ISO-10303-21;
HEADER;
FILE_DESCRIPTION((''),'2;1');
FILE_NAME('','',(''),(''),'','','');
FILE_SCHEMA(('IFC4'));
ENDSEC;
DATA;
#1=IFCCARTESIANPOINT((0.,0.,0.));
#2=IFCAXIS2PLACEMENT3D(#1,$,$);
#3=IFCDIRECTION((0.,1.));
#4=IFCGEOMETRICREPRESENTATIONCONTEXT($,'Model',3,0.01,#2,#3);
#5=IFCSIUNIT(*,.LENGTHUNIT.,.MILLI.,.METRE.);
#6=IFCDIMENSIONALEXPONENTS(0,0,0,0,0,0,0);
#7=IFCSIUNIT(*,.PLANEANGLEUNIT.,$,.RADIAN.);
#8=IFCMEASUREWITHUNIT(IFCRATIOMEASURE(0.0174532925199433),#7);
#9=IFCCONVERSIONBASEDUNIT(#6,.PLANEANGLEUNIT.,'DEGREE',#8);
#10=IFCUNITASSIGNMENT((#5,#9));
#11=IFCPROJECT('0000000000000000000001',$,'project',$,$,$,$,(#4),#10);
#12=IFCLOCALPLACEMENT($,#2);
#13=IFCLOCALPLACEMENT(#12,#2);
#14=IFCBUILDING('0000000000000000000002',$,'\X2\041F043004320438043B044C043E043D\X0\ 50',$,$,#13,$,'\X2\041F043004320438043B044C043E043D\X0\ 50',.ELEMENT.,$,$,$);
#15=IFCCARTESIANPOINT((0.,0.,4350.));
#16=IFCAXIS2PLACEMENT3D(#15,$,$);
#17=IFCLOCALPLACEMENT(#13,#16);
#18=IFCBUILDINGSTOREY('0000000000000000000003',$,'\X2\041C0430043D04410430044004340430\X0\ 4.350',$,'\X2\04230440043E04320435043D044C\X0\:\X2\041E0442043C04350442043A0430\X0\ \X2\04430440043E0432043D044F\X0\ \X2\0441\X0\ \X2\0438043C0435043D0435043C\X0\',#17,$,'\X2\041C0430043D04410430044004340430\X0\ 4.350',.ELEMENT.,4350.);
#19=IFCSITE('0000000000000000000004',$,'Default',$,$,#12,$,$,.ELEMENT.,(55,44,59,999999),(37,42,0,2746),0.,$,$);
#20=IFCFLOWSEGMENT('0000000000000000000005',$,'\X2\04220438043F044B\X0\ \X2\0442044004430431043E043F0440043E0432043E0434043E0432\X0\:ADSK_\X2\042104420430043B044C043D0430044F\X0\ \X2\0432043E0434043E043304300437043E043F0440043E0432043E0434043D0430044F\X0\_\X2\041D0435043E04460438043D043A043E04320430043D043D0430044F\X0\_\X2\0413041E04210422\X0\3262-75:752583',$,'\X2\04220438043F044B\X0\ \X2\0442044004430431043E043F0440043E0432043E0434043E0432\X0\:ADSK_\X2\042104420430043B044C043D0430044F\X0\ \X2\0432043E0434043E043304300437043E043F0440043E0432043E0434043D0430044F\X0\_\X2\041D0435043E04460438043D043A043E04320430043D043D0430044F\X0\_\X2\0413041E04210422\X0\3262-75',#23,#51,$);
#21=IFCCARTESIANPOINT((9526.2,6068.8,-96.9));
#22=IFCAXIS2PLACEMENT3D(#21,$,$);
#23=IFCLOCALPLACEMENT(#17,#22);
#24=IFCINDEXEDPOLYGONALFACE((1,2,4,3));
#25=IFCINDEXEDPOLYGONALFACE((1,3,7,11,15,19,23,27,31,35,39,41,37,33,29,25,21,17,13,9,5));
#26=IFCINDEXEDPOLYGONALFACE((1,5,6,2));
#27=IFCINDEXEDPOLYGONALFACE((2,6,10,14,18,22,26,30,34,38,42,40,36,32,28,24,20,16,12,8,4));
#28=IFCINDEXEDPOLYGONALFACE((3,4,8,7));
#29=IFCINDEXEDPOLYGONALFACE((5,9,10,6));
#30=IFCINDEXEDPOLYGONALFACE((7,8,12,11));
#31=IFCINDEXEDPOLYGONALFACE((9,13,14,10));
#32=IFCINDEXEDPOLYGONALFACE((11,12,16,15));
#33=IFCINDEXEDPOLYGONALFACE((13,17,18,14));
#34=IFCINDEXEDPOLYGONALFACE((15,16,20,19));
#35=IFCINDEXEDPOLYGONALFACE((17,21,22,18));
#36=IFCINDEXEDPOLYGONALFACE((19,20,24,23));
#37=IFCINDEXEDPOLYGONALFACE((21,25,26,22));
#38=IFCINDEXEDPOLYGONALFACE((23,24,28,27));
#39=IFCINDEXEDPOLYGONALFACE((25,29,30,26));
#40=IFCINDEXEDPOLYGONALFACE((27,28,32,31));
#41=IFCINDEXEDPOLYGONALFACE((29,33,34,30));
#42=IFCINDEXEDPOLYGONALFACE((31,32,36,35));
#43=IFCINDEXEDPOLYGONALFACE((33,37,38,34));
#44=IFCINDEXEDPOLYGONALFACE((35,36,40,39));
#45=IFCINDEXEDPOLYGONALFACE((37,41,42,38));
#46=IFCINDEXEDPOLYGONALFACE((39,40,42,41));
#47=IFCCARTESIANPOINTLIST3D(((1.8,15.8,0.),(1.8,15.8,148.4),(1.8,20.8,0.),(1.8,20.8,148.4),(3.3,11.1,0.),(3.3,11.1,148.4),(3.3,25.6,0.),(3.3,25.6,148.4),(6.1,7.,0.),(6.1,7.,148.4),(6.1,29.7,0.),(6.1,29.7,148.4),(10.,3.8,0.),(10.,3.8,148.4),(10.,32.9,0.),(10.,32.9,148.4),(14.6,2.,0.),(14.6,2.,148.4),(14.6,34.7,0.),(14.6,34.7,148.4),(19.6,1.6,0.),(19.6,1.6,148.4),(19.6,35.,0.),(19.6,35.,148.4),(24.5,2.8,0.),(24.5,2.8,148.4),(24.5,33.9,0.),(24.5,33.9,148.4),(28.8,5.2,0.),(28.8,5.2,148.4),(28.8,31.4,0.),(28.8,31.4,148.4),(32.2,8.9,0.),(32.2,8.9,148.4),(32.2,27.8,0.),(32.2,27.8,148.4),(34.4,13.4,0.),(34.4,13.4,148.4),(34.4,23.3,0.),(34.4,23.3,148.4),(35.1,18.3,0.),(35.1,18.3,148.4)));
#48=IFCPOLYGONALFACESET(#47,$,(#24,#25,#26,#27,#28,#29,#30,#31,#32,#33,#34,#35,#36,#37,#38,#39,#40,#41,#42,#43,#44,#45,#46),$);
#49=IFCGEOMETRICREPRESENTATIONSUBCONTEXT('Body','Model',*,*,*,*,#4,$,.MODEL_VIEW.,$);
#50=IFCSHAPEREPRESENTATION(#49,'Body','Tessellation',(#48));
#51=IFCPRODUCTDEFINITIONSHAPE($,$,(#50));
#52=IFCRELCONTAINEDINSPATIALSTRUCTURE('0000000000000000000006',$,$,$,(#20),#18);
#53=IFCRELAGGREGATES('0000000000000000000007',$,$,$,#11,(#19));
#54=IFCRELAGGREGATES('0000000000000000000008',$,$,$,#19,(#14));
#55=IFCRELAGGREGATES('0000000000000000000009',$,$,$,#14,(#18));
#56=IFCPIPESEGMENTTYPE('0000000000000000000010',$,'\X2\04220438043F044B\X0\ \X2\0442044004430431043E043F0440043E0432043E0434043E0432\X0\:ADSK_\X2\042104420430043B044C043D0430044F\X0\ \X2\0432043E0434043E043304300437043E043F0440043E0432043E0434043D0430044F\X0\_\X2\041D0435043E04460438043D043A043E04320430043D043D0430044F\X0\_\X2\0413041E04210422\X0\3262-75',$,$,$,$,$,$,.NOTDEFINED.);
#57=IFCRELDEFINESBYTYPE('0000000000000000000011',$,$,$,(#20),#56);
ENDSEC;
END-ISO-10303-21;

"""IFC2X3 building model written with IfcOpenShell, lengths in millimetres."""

from ifc_helpers import new_model, entity, si_unit, converted_unit, direction, frame, origin, origin_2d_with_axis, place, context, subcontext, project, spatial, circle, extrude, type_object, element, save


model = new_model("IFC2X3")

# Units and contexts
model_context = context("Model", 3, precision=0.01, world=origin(), true_north=direction((0.0, 1.0)))
body_context = subcontext(model_context, "Body", "Model", "MODEL_VIEW")
ifc_project = project(units=[si_unit("LENGTHUNIT", "METRE", prefix="MILLI"), converted_unit("PLANEANGLEUNIT", "DEGREE", entity("IfcRatioMeasure", 0.0174532925199433), si_unit("PLANEANGLEUNIT", "RADIAN"), dimensions=[0, 0, 0, 0, 0, 0, 0])], contexts=[model_context])

# Site, building, storey
site_placement = place(None, origin())
site = spatial("IfcSite", under=ifc_project, at=site_placement, Name="Default", CompositionType="ELEMENT", RefLatitude=(55, 44, 59, 999999), RefLongitude=(37, 42, 0, 2746), RefElevation=0.0)
building_placement = place(site_placement, origin())
building = spatial("IfcBuilding", under=site, at=building_placement, Name="Павильон 50", LongName="Павильон 50", CompositionType="ELEMENT")
storey_placement = place(building_placement, frame((0.0, 0.0, 4350.0)))
storey = spatial("IfcBuildingStorey", under=building, at=storey_placement, Name="Мансарда 4.350", ObjectType="Уровень:Отметка уровня с именем", LongName="Мансарда 4.350", CompositionType="ELEMENT", Elevation=4350.0)

# Flow segment
pipe_segment_type = type_object("IfcPipeSegmentType", Name="Типы трубопроводов:ADSK_Стальная водогазопроводная_Неоцинкованная_ГОСТ3262-75", PredefinedType="NOTDEFINED")
flow_segment_1_placement = place(storey_placement, frame((9526.2, 6068.8, -96.9)))
element("IfcFlowSegment", 1, at=flow_segment_1_placement, inside=storey, type_object=pipe_segment_type, Name="Типы трубопроводов:ADSK_Стальная водогазопроводная_Неоцинкованная_ГОСТ3262-75:752583", ObjectType="Типы трубопроводов:ADSK_Стальная водогазопроводная_Неоцинкованная_ГОСТ3262-75", context=body_context, shape_type="SweptSolid", body=[
    extrude(circle(Radius=16.8, at=origin_2d_with_axis()), frame((18.3, 18.3, 0.0)), (0.0, 0.0, 1.0), 148.4),
])

save(model, "model.ifc")
